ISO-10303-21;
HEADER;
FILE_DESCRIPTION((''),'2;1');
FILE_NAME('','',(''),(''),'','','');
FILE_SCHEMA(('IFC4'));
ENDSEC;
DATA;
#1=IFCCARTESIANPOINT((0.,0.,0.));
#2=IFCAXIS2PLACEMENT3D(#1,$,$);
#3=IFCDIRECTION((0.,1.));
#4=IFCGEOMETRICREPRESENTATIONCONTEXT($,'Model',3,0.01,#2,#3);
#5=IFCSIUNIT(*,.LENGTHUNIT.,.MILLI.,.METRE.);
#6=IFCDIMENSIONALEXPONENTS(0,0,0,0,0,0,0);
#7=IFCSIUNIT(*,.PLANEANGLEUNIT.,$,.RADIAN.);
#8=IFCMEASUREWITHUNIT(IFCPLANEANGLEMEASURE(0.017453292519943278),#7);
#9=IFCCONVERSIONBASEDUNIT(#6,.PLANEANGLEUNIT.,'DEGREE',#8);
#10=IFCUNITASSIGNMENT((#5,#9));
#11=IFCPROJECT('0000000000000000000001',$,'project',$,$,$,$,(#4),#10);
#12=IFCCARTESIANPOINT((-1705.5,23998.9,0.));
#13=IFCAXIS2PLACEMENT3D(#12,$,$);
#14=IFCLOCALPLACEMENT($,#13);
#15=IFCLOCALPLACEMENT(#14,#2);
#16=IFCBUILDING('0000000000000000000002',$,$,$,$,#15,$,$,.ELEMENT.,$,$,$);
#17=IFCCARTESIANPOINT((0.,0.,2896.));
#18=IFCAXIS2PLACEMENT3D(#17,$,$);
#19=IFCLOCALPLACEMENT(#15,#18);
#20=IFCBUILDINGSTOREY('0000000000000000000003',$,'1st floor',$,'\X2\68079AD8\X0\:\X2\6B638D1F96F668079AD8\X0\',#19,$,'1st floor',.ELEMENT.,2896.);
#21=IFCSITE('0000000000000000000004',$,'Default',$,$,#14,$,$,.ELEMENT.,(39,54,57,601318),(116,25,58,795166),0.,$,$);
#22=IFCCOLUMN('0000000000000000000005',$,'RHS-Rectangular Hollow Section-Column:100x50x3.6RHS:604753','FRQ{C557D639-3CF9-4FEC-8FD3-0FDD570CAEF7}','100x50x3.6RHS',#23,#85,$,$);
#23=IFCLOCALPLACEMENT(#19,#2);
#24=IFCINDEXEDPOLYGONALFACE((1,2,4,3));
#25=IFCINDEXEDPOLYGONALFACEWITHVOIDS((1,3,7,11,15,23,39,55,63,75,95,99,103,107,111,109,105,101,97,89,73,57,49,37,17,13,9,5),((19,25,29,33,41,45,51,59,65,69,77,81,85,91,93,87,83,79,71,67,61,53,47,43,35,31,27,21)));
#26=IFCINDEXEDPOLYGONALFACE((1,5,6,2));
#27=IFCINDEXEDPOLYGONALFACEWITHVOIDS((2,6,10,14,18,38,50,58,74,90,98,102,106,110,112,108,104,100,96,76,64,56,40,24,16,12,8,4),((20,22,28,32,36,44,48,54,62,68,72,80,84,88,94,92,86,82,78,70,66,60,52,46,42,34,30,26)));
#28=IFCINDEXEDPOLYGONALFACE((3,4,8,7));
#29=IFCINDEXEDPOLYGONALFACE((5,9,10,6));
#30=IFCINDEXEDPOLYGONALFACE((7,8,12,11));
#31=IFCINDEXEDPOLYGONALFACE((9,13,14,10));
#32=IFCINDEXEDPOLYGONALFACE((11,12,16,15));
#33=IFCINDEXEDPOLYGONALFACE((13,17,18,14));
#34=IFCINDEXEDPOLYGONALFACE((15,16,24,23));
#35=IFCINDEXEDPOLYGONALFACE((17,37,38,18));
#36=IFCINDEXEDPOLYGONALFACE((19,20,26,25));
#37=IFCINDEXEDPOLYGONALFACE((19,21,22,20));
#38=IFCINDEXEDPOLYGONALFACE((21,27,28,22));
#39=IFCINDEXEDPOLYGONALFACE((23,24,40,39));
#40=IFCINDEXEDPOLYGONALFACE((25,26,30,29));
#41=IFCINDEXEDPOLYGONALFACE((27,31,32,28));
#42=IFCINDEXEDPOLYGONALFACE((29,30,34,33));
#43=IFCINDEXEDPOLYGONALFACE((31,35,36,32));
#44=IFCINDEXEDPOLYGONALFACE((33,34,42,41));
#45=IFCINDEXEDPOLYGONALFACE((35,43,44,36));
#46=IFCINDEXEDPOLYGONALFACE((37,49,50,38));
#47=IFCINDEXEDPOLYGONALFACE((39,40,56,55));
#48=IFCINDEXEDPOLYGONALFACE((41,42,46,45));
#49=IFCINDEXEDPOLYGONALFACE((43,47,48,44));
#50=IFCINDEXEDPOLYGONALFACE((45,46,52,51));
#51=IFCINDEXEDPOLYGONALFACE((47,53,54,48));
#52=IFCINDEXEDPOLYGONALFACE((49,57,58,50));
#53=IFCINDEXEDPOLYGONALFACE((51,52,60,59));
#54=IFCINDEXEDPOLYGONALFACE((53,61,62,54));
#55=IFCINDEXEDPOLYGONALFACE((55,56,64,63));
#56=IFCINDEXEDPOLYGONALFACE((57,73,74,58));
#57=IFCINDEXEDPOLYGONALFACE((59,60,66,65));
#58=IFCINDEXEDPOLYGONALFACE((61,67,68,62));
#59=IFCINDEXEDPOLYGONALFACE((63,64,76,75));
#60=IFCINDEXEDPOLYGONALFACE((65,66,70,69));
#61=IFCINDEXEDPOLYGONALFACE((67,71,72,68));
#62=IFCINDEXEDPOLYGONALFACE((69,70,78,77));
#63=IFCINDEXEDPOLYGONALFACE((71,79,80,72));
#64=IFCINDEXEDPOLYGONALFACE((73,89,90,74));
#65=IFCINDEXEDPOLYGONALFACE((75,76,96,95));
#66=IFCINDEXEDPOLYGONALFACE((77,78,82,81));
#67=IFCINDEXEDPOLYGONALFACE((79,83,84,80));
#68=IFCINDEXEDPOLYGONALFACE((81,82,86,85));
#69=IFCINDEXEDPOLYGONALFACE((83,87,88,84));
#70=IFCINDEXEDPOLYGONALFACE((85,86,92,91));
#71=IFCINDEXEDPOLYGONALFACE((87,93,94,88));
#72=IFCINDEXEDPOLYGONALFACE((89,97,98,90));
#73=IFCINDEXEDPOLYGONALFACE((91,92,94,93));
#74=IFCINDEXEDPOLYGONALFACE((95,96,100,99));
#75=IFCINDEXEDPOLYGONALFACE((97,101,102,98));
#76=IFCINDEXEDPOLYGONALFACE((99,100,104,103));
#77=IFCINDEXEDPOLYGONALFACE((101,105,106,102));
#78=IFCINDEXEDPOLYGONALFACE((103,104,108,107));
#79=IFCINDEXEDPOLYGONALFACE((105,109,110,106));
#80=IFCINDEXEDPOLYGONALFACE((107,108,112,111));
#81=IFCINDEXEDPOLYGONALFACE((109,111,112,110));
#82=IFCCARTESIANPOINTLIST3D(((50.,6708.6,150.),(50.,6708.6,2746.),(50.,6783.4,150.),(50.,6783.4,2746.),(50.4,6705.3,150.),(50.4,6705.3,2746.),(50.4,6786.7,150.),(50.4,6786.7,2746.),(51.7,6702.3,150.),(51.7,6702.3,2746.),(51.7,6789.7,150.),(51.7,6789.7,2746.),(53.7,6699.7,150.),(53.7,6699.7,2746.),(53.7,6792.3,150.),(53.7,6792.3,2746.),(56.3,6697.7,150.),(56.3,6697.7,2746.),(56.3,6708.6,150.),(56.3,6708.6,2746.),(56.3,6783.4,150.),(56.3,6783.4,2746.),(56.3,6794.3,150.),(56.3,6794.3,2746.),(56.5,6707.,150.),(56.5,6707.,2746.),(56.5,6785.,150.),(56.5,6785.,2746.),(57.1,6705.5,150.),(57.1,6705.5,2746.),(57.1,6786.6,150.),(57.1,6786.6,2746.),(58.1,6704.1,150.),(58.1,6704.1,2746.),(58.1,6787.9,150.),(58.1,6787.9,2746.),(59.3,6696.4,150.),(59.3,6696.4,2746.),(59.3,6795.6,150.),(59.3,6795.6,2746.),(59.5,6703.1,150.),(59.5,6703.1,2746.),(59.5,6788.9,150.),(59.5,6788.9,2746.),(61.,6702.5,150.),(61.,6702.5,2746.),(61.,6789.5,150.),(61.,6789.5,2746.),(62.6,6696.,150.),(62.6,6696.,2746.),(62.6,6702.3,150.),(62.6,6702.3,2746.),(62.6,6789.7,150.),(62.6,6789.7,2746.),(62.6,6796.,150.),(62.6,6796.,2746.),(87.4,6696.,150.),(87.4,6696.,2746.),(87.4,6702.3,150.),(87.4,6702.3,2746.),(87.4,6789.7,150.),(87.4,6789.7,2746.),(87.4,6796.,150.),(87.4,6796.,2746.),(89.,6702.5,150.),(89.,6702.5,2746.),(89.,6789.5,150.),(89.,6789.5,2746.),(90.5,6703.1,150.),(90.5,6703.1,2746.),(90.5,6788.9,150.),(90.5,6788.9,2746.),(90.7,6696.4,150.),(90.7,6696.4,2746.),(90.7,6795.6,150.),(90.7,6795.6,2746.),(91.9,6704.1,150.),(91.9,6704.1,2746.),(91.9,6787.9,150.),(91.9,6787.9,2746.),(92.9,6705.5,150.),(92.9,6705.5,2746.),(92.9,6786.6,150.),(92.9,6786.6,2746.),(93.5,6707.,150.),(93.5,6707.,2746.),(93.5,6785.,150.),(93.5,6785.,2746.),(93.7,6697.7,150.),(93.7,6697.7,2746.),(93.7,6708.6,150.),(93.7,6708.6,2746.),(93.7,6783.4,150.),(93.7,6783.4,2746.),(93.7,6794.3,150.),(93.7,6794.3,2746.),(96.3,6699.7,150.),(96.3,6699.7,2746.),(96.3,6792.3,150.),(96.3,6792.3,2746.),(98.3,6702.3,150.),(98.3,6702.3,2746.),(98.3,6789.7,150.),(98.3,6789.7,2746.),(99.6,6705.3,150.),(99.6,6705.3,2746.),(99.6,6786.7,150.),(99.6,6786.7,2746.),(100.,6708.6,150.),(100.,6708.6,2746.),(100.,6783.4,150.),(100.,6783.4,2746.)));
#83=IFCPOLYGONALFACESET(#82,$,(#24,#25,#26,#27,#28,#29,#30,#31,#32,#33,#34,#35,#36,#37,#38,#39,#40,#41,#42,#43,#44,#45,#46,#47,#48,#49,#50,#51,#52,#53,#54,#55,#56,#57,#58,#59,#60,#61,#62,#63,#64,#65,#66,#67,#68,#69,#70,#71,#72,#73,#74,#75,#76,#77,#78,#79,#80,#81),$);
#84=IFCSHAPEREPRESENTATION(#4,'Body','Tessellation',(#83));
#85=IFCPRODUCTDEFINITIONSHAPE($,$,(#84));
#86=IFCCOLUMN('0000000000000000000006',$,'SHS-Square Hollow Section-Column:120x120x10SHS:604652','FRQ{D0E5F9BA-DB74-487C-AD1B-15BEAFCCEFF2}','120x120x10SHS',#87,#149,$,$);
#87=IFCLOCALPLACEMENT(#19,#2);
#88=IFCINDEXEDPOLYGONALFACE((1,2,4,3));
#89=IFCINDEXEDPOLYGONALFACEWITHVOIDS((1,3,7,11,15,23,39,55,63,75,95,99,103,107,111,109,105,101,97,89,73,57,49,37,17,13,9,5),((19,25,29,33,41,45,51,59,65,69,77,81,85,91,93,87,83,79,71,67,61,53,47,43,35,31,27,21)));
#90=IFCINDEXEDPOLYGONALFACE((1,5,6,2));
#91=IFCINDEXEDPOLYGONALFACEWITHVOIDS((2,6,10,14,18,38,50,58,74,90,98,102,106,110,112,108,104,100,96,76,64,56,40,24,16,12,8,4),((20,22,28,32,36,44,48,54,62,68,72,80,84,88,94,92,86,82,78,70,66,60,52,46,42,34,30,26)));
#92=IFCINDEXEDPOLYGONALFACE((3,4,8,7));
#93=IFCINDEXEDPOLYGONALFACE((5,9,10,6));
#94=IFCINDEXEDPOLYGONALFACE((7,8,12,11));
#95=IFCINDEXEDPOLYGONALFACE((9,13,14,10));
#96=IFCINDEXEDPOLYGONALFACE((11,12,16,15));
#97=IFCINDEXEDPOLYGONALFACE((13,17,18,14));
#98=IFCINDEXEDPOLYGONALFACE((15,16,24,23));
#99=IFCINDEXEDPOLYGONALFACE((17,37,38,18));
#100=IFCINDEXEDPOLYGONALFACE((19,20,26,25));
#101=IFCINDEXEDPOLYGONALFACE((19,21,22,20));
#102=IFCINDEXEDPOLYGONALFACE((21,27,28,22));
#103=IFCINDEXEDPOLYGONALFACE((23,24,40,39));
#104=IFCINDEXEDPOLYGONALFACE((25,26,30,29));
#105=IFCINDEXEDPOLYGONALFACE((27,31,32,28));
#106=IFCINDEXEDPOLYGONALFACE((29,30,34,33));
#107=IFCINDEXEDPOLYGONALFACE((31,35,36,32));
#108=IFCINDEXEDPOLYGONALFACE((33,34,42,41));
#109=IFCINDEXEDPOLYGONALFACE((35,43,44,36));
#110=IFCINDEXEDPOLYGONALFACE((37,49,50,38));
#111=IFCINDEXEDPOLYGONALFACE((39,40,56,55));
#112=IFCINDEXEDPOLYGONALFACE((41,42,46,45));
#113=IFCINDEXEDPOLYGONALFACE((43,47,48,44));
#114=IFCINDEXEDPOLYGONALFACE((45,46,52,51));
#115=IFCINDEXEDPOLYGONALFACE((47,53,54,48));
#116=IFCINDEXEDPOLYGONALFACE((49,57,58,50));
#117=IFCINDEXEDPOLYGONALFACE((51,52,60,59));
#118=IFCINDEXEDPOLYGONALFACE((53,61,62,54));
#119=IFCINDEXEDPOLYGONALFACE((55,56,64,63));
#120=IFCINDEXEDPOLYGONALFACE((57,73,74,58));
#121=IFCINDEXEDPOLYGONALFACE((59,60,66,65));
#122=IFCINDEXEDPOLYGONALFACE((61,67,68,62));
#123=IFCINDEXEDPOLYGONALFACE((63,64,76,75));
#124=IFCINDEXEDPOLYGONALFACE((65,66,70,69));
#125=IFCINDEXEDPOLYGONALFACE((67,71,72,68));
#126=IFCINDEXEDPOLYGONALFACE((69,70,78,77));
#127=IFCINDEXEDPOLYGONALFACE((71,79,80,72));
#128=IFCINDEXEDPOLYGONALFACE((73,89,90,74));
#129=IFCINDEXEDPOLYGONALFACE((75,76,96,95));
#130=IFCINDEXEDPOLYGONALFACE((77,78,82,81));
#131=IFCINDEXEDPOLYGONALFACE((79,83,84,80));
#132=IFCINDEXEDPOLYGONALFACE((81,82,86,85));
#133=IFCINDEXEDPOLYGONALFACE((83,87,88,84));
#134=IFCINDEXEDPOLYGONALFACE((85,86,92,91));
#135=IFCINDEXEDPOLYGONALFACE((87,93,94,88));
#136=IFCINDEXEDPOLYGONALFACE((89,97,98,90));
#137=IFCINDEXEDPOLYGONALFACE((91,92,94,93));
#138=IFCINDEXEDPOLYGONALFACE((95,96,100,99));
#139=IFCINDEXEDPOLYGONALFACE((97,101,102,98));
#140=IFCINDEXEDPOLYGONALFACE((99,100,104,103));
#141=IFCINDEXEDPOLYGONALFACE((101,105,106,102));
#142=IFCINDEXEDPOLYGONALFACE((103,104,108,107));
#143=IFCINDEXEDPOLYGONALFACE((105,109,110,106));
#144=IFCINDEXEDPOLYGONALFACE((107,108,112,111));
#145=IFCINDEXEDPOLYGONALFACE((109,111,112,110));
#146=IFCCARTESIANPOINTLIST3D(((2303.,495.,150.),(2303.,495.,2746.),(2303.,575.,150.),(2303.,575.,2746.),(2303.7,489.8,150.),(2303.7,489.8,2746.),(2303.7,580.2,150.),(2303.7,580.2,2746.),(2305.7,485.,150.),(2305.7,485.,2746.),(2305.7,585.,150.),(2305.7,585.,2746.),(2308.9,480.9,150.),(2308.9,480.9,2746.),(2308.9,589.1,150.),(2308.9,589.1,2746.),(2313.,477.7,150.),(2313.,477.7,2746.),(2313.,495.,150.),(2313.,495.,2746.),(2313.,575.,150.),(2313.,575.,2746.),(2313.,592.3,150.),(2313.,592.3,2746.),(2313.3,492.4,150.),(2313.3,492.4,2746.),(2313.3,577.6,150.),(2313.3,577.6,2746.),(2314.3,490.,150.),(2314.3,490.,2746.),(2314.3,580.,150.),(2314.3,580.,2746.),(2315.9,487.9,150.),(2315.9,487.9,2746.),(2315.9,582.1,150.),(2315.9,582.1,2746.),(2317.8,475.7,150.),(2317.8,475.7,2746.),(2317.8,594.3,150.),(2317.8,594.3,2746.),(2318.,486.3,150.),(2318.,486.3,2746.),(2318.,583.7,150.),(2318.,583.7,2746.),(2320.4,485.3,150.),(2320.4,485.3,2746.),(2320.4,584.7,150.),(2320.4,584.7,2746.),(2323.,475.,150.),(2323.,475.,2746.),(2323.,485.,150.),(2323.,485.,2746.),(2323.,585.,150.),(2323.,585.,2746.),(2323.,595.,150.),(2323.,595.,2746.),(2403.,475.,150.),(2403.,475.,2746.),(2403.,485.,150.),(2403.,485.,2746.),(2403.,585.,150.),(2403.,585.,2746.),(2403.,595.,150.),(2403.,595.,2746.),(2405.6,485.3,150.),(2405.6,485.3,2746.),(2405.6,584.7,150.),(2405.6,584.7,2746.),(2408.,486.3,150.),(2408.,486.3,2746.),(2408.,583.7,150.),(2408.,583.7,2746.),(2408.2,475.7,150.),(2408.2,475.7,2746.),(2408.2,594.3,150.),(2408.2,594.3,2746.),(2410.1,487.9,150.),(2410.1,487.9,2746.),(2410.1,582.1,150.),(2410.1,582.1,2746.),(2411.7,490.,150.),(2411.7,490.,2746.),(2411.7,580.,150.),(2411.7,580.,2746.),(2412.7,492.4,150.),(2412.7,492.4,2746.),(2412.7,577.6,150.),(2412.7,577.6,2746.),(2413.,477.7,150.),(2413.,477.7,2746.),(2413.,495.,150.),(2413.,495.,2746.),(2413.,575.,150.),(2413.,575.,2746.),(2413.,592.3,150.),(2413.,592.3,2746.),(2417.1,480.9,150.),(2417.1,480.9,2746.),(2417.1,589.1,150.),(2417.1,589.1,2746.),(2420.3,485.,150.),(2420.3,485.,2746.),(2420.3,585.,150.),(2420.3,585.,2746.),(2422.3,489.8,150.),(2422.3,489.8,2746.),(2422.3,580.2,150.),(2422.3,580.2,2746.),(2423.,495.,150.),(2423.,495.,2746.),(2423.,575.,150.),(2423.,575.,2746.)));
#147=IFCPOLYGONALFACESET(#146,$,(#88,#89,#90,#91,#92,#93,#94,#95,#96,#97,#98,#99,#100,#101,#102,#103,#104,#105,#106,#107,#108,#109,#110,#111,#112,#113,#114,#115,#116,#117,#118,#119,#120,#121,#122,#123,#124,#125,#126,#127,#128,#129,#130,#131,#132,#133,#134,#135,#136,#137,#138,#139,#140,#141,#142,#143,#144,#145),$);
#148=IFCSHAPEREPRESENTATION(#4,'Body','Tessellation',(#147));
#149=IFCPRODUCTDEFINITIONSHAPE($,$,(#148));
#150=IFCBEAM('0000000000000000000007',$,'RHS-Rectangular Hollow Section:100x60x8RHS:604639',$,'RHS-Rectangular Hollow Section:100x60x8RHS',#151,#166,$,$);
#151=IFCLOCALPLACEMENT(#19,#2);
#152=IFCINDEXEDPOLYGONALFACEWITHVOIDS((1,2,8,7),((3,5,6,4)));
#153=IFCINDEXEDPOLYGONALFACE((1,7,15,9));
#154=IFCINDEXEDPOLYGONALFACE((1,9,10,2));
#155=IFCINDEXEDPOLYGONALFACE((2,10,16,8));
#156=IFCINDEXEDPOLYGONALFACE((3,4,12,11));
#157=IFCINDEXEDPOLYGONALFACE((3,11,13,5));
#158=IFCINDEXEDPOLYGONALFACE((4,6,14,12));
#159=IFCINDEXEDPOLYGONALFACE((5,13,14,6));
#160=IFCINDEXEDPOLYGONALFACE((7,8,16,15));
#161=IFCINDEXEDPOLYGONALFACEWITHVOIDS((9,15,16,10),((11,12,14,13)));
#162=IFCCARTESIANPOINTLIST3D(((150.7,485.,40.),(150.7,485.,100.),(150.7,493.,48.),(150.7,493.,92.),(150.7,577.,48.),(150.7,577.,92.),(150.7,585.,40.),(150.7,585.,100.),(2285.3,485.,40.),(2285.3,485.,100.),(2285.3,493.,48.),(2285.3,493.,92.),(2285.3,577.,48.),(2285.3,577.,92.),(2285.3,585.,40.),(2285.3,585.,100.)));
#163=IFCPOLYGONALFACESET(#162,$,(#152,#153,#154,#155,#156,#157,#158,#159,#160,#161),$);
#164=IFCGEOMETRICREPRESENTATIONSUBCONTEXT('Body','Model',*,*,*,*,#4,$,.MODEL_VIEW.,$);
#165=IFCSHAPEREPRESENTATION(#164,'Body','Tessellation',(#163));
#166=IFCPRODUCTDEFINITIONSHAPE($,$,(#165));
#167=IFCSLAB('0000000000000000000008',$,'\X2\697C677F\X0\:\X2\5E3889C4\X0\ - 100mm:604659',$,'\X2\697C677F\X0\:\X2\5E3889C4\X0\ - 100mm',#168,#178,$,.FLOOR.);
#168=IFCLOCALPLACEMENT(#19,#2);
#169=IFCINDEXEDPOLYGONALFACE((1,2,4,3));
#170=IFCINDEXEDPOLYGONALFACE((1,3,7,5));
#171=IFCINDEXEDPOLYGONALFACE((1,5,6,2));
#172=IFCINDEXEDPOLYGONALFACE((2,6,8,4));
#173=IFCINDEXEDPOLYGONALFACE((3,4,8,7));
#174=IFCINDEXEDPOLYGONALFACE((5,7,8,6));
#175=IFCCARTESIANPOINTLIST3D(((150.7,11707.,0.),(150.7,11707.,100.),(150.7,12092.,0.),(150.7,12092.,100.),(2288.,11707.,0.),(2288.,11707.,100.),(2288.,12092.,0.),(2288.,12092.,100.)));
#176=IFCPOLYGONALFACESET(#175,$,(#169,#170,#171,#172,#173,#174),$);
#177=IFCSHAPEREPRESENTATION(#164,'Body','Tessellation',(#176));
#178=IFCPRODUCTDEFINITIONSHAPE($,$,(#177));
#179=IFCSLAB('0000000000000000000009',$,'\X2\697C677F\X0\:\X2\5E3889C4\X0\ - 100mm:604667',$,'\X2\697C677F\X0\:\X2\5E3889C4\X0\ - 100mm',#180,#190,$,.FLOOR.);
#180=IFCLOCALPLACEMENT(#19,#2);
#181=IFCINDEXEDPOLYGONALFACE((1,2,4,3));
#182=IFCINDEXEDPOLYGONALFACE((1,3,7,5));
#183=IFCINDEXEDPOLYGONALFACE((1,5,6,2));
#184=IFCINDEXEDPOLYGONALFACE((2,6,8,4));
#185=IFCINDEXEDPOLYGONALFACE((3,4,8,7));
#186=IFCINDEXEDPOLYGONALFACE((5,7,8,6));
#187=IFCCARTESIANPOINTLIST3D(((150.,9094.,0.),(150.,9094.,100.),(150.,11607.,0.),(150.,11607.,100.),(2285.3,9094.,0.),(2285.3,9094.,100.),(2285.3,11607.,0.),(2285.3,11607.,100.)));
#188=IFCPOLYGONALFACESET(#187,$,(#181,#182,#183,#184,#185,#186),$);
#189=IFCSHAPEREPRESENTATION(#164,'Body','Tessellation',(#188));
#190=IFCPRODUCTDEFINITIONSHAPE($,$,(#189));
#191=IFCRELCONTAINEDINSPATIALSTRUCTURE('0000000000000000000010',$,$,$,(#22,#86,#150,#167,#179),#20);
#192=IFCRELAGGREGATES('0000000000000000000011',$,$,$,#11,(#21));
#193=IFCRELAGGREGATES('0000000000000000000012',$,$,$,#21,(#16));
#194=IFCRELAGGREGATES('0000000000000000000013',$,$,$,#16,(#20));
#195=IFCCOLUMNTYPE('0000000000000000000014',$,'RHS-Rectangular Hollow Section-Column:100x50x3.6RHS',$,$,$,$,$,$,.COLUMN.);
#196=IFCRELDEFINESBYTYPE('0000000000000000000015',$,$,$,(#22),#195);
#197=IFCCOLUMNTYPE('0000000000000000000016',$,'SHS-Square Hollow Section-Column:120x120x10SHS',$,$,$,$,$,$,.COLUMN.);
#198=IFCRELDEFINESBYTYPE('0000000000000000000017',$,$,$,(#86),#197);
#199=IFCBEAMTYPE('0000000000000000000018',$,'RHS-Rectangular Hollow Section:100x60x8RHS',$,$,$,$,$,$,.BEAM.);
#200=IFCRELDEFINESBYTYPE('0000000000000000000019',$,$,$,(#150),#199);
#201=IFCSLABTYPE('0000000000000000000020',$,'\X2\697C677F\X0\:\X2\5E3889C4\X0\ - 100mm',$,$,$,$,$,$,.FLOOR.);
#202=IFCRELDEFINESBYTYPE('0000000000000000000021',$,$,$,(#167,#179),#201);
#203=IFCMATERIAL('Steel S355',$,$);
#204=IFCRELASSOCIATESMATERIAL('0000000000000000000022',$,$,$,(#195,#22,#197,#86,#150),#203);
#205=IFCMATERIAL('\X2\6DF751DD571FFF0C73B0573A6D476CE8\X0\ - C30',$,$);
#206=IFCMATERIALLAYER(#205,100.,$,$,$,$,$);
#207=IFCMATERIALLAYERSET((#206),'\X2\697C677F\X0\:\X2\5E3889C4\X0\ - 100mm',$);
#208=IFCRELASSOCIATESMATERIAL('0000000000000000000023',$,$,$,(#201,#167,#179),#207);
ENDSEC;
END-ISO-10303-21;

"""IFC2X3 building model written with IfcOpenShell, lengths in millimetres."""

from ifc_helpers import new_model, entity, si_unit, converted_unit, direction, frame, frame_2d, origin, origin_2d, origin_2d_with_axis, place, context, subcontext, project, spatial, rectangle, hollow_rectangle, extrude, boolean, clip, halfspace, material, layer, layer_set, layer_usage, type_object, element, save


model = new_model("IFC2X3")

# Units and contexts
model_context = context("Model", 3, precision=0.01, world=origin(), true_north=direction((0.0, 1.0)))
body_context = subcontext(model_context, "Body", "Model", "MODEL_VIEW")
ifc_project = project(units=[si_unit("LENGTHUNIT", "METRE", prefix="MILLI"), converted_unit("PLANEANGLEUNIT", "DEGREE", entity("IfcPlaneAngleMeasure", 0.017453292519943278), si_unit("PLANEANGLEUNIT", "RADIAN"), dimensions=[0, 0, 0, 0, 0, 0, 0])], contexts=[model_context])

# Site, building, storey
site_placement = place(None, frame((-1705.5, 23998.9, 0.0)))
site = spatial("IfcSite", under=ifc_project, at=site_placement, Name="Default", CompositionType="ELEMENT", RefLatitude=(39, 54, 57, 601318), RefLongitude=(116, 25, 58, 795166), RefElevation=0.0)
building_placement = place(site_placement, origin())
building = spatial("IfcBuilding", under=site, at=building_placement, CompositionType="ELEMENT")
storey_placement = place(building_placement, frame((0.0, 0.0, 2896.0)))
storey = spatial("IfcBuildingStorey", under=building, at=storey_placement, Name="1st floor", ObjectType="标高:正负零标高", LongName="1st floor", CompositionType="ELEMENT", Elevation=2896.0)

# Shared definitions
ifc_material_1 = material(Name="Steel S355")

# Columns
column_type_1 = type_object("IfcColumnType", Name="RHS-Rectangular Hollow Section-Column:100x50x3.6RHS", PredefinedType="COLUMN", material=ifc_material_1)
column_1_placement = place(storey_placement, frame((75.0, 6746.0, 2746.0), z_axis=(0.0, 0.0, 1.0), x_axis=(-1.0, 0.0, 0.0)))
element("IfcColumn", 1, at=column_1_placement, inside=storey, type_object=column_type_1, material=ifc_material_1, Name="RHS-Rectangular Hollow Section-Column:100x50x3.6RHS:604753", Description="FRQ{C557D639-3CF9-4FEC-8FD3-0FDD570CAEF7}", ObjectType="100x50x3.6RHS", context=model_context, shape_type="Clipping", body=[
    clip(extrude(hollow_rectangle(XDim=50.0, YDim=100.0, WallThickness=6.3, InnerFilletRadius=6.3, OuterFilletRadius=12.6, at=origin_2d()), origin(), (0.0, 0.0, -1.0), 2651.9), halfspace(frame((75.0, 6746.0, -2596.0), z_axis=(0.0, 0.0, 1.0), x_axis=(-1.0, 0.0, 0.0)), True)),
])
column_type_2 = type_object("IfcColumnType", Name="SHS-Square Hollow Section-Column:120x120x10SHS", PredefinedType="COLUMN", material=ifc_material_1)
column_2_placement = place(storey_placement, frame((2363.0, 535.0, 2746.0), z_axis=(0.0, 0.0, 1.0), x_axis=(0.0, -1.0, 0.0)))
element("IfcColumn", 2, at=column_2_placement, inside=storey, type_object=column_type_2, material=ifc_material_1, Name="SHS-Square Hollow Section-Column:120x120x10SHS:604652", Description="FRQ{D0E5F9BA-DB74-487C-AD1B-15BEAFCCEFF2}", ObjectType="120x120x10SHS", context=model_context, shape_type="Clipping", body=[
    clip(extrude(hollow_rectangle(XDim=120.0, YDim=120.0, WallThickness=10.0, InnerFilletRadius=10.0, OuterFilletRadius=20.0, at=origin_2d()), origin(), (0.0, 0.0, -1.0), 2680.9), halfspace(frame((535.0, -2363.0, -2596.0), z_axis=(0.0, 0.0, 1.0), x_axis=(0.0, 1.0, 0.0)), True)),
])

# Beam
beam_type_1 = type_object("IfcBeamType", Name="RHS-Rectangular Hollow Section:100x60x8RHS", PredefinedType="BEAM")
beam_1_placement = place(storey_placement, frame((150.7, 585.0, 70.0)))
element("IfcBeam", 3, at=beam_1_placement, inside=storey, type_object=beam_type_1, material=ifc_material_1, Name="RHS-Rectangular Hollow Section:100x60x8RHS:604639", ObjectType="RHS-Rectangular Hollow Section:100x60x8RHS", context=body_context, shape_type="SweptSolid", body=[
    boolean("DIFFERENCE", extrude(rectangle(XDim=60.0, YDim=100.0, at=frame_2d((0.0, 0.0), x_axis=(1.0, 0.0))), frame((0.0, -50.0, 0.0), z_axis=(1.0, 0.0, 0.0), x_axis=(0.0, 0.0, -1.0)), (0.0, 0.0, 1.0), 2134.6), extrude(rectangle(XDim=44.0, YDim=84.0, at=frame_2d((0.0, 0.0), x_axis=(0.0, 1.0))), frame((2134.6, -50.0, 0.0), z_axis=(-1.0, 0.0, 0.0), x_axis=(0.0, 1.0, 0.0)), (0.0, 0.0, 1.0), 2134.6)),
])

# Slabs
ifc_material_2 = material(Name="混凝土，现场浇注 - C30")
ifc_layer_1 = layer(ifc_material_2, 100.0)
ifc_layer_set_1 = layer_set([ifc_layer_1], Name="楼板:常规 - 100mm")
ifc_layer_usage_1 = layer_usage(ifc_layer_set_1, "AXIS3", "POSITIVE", 0.0)
slab_type = type_object("IfcSlabType", Name="楼板:常规 - 100mm", PredefinedType="FLOOR", material=ifc_layer_set_1)
slab_1_placement = place(storey_placement, origin())
element("IfcSlab", 4, at=slab_1_placement, inside=storey, type_object=slab_type, material=ifc_layer_usage_1, Name="楼板:常规 - 100mm:604659", ObjectType="楼板:常规 - 100mm", PredefinedType="FLOOR", context=body_context, shape_type="SweptSolid", body=[
    extrude(rectangle(XDim=385.0, YDim=2137.3, at=origin_2d_with_axis()), frame((1219.3, 11899.5, 100.0), z_axis=(0.0, 0.0, -1.0), x_axis=(0.0, 1.0, 0.0)), (0.0, 0.0, 1.0), 100.0),
])
ifc_layer_usage_2 = layer_usage(ifc_layer_set_1, "AXIS3", "POSITIVE", 0.0)
slab_2_placement = place(storey_placement, origin())
element("IfcSlab", 5, at=slab_2_placement, inside=storey, type_object=slab_type, material=ifc_layer_usage_2, Name="楼板:常规 - 100mm:604667", ObjectType="楼板:常规 - 100mm", PredefinedType="FLOOR", context=body_context, shape_type="SweptSolid", body=[
    extrude(rectangle(XDim=2513.0, YDim=2135.3, at=frame_2d((0.0, 0.0), x_axis=(1.0, 0.0))), frame((1217.6, 10350.5, 100.0), z_axis=(0.0, 0.0, -1.0), x_axis=(0.0, 1.0, 0.0)), (0.0, 0.0, 1.0), 100.0),
])

save(model, "model.ifc")
